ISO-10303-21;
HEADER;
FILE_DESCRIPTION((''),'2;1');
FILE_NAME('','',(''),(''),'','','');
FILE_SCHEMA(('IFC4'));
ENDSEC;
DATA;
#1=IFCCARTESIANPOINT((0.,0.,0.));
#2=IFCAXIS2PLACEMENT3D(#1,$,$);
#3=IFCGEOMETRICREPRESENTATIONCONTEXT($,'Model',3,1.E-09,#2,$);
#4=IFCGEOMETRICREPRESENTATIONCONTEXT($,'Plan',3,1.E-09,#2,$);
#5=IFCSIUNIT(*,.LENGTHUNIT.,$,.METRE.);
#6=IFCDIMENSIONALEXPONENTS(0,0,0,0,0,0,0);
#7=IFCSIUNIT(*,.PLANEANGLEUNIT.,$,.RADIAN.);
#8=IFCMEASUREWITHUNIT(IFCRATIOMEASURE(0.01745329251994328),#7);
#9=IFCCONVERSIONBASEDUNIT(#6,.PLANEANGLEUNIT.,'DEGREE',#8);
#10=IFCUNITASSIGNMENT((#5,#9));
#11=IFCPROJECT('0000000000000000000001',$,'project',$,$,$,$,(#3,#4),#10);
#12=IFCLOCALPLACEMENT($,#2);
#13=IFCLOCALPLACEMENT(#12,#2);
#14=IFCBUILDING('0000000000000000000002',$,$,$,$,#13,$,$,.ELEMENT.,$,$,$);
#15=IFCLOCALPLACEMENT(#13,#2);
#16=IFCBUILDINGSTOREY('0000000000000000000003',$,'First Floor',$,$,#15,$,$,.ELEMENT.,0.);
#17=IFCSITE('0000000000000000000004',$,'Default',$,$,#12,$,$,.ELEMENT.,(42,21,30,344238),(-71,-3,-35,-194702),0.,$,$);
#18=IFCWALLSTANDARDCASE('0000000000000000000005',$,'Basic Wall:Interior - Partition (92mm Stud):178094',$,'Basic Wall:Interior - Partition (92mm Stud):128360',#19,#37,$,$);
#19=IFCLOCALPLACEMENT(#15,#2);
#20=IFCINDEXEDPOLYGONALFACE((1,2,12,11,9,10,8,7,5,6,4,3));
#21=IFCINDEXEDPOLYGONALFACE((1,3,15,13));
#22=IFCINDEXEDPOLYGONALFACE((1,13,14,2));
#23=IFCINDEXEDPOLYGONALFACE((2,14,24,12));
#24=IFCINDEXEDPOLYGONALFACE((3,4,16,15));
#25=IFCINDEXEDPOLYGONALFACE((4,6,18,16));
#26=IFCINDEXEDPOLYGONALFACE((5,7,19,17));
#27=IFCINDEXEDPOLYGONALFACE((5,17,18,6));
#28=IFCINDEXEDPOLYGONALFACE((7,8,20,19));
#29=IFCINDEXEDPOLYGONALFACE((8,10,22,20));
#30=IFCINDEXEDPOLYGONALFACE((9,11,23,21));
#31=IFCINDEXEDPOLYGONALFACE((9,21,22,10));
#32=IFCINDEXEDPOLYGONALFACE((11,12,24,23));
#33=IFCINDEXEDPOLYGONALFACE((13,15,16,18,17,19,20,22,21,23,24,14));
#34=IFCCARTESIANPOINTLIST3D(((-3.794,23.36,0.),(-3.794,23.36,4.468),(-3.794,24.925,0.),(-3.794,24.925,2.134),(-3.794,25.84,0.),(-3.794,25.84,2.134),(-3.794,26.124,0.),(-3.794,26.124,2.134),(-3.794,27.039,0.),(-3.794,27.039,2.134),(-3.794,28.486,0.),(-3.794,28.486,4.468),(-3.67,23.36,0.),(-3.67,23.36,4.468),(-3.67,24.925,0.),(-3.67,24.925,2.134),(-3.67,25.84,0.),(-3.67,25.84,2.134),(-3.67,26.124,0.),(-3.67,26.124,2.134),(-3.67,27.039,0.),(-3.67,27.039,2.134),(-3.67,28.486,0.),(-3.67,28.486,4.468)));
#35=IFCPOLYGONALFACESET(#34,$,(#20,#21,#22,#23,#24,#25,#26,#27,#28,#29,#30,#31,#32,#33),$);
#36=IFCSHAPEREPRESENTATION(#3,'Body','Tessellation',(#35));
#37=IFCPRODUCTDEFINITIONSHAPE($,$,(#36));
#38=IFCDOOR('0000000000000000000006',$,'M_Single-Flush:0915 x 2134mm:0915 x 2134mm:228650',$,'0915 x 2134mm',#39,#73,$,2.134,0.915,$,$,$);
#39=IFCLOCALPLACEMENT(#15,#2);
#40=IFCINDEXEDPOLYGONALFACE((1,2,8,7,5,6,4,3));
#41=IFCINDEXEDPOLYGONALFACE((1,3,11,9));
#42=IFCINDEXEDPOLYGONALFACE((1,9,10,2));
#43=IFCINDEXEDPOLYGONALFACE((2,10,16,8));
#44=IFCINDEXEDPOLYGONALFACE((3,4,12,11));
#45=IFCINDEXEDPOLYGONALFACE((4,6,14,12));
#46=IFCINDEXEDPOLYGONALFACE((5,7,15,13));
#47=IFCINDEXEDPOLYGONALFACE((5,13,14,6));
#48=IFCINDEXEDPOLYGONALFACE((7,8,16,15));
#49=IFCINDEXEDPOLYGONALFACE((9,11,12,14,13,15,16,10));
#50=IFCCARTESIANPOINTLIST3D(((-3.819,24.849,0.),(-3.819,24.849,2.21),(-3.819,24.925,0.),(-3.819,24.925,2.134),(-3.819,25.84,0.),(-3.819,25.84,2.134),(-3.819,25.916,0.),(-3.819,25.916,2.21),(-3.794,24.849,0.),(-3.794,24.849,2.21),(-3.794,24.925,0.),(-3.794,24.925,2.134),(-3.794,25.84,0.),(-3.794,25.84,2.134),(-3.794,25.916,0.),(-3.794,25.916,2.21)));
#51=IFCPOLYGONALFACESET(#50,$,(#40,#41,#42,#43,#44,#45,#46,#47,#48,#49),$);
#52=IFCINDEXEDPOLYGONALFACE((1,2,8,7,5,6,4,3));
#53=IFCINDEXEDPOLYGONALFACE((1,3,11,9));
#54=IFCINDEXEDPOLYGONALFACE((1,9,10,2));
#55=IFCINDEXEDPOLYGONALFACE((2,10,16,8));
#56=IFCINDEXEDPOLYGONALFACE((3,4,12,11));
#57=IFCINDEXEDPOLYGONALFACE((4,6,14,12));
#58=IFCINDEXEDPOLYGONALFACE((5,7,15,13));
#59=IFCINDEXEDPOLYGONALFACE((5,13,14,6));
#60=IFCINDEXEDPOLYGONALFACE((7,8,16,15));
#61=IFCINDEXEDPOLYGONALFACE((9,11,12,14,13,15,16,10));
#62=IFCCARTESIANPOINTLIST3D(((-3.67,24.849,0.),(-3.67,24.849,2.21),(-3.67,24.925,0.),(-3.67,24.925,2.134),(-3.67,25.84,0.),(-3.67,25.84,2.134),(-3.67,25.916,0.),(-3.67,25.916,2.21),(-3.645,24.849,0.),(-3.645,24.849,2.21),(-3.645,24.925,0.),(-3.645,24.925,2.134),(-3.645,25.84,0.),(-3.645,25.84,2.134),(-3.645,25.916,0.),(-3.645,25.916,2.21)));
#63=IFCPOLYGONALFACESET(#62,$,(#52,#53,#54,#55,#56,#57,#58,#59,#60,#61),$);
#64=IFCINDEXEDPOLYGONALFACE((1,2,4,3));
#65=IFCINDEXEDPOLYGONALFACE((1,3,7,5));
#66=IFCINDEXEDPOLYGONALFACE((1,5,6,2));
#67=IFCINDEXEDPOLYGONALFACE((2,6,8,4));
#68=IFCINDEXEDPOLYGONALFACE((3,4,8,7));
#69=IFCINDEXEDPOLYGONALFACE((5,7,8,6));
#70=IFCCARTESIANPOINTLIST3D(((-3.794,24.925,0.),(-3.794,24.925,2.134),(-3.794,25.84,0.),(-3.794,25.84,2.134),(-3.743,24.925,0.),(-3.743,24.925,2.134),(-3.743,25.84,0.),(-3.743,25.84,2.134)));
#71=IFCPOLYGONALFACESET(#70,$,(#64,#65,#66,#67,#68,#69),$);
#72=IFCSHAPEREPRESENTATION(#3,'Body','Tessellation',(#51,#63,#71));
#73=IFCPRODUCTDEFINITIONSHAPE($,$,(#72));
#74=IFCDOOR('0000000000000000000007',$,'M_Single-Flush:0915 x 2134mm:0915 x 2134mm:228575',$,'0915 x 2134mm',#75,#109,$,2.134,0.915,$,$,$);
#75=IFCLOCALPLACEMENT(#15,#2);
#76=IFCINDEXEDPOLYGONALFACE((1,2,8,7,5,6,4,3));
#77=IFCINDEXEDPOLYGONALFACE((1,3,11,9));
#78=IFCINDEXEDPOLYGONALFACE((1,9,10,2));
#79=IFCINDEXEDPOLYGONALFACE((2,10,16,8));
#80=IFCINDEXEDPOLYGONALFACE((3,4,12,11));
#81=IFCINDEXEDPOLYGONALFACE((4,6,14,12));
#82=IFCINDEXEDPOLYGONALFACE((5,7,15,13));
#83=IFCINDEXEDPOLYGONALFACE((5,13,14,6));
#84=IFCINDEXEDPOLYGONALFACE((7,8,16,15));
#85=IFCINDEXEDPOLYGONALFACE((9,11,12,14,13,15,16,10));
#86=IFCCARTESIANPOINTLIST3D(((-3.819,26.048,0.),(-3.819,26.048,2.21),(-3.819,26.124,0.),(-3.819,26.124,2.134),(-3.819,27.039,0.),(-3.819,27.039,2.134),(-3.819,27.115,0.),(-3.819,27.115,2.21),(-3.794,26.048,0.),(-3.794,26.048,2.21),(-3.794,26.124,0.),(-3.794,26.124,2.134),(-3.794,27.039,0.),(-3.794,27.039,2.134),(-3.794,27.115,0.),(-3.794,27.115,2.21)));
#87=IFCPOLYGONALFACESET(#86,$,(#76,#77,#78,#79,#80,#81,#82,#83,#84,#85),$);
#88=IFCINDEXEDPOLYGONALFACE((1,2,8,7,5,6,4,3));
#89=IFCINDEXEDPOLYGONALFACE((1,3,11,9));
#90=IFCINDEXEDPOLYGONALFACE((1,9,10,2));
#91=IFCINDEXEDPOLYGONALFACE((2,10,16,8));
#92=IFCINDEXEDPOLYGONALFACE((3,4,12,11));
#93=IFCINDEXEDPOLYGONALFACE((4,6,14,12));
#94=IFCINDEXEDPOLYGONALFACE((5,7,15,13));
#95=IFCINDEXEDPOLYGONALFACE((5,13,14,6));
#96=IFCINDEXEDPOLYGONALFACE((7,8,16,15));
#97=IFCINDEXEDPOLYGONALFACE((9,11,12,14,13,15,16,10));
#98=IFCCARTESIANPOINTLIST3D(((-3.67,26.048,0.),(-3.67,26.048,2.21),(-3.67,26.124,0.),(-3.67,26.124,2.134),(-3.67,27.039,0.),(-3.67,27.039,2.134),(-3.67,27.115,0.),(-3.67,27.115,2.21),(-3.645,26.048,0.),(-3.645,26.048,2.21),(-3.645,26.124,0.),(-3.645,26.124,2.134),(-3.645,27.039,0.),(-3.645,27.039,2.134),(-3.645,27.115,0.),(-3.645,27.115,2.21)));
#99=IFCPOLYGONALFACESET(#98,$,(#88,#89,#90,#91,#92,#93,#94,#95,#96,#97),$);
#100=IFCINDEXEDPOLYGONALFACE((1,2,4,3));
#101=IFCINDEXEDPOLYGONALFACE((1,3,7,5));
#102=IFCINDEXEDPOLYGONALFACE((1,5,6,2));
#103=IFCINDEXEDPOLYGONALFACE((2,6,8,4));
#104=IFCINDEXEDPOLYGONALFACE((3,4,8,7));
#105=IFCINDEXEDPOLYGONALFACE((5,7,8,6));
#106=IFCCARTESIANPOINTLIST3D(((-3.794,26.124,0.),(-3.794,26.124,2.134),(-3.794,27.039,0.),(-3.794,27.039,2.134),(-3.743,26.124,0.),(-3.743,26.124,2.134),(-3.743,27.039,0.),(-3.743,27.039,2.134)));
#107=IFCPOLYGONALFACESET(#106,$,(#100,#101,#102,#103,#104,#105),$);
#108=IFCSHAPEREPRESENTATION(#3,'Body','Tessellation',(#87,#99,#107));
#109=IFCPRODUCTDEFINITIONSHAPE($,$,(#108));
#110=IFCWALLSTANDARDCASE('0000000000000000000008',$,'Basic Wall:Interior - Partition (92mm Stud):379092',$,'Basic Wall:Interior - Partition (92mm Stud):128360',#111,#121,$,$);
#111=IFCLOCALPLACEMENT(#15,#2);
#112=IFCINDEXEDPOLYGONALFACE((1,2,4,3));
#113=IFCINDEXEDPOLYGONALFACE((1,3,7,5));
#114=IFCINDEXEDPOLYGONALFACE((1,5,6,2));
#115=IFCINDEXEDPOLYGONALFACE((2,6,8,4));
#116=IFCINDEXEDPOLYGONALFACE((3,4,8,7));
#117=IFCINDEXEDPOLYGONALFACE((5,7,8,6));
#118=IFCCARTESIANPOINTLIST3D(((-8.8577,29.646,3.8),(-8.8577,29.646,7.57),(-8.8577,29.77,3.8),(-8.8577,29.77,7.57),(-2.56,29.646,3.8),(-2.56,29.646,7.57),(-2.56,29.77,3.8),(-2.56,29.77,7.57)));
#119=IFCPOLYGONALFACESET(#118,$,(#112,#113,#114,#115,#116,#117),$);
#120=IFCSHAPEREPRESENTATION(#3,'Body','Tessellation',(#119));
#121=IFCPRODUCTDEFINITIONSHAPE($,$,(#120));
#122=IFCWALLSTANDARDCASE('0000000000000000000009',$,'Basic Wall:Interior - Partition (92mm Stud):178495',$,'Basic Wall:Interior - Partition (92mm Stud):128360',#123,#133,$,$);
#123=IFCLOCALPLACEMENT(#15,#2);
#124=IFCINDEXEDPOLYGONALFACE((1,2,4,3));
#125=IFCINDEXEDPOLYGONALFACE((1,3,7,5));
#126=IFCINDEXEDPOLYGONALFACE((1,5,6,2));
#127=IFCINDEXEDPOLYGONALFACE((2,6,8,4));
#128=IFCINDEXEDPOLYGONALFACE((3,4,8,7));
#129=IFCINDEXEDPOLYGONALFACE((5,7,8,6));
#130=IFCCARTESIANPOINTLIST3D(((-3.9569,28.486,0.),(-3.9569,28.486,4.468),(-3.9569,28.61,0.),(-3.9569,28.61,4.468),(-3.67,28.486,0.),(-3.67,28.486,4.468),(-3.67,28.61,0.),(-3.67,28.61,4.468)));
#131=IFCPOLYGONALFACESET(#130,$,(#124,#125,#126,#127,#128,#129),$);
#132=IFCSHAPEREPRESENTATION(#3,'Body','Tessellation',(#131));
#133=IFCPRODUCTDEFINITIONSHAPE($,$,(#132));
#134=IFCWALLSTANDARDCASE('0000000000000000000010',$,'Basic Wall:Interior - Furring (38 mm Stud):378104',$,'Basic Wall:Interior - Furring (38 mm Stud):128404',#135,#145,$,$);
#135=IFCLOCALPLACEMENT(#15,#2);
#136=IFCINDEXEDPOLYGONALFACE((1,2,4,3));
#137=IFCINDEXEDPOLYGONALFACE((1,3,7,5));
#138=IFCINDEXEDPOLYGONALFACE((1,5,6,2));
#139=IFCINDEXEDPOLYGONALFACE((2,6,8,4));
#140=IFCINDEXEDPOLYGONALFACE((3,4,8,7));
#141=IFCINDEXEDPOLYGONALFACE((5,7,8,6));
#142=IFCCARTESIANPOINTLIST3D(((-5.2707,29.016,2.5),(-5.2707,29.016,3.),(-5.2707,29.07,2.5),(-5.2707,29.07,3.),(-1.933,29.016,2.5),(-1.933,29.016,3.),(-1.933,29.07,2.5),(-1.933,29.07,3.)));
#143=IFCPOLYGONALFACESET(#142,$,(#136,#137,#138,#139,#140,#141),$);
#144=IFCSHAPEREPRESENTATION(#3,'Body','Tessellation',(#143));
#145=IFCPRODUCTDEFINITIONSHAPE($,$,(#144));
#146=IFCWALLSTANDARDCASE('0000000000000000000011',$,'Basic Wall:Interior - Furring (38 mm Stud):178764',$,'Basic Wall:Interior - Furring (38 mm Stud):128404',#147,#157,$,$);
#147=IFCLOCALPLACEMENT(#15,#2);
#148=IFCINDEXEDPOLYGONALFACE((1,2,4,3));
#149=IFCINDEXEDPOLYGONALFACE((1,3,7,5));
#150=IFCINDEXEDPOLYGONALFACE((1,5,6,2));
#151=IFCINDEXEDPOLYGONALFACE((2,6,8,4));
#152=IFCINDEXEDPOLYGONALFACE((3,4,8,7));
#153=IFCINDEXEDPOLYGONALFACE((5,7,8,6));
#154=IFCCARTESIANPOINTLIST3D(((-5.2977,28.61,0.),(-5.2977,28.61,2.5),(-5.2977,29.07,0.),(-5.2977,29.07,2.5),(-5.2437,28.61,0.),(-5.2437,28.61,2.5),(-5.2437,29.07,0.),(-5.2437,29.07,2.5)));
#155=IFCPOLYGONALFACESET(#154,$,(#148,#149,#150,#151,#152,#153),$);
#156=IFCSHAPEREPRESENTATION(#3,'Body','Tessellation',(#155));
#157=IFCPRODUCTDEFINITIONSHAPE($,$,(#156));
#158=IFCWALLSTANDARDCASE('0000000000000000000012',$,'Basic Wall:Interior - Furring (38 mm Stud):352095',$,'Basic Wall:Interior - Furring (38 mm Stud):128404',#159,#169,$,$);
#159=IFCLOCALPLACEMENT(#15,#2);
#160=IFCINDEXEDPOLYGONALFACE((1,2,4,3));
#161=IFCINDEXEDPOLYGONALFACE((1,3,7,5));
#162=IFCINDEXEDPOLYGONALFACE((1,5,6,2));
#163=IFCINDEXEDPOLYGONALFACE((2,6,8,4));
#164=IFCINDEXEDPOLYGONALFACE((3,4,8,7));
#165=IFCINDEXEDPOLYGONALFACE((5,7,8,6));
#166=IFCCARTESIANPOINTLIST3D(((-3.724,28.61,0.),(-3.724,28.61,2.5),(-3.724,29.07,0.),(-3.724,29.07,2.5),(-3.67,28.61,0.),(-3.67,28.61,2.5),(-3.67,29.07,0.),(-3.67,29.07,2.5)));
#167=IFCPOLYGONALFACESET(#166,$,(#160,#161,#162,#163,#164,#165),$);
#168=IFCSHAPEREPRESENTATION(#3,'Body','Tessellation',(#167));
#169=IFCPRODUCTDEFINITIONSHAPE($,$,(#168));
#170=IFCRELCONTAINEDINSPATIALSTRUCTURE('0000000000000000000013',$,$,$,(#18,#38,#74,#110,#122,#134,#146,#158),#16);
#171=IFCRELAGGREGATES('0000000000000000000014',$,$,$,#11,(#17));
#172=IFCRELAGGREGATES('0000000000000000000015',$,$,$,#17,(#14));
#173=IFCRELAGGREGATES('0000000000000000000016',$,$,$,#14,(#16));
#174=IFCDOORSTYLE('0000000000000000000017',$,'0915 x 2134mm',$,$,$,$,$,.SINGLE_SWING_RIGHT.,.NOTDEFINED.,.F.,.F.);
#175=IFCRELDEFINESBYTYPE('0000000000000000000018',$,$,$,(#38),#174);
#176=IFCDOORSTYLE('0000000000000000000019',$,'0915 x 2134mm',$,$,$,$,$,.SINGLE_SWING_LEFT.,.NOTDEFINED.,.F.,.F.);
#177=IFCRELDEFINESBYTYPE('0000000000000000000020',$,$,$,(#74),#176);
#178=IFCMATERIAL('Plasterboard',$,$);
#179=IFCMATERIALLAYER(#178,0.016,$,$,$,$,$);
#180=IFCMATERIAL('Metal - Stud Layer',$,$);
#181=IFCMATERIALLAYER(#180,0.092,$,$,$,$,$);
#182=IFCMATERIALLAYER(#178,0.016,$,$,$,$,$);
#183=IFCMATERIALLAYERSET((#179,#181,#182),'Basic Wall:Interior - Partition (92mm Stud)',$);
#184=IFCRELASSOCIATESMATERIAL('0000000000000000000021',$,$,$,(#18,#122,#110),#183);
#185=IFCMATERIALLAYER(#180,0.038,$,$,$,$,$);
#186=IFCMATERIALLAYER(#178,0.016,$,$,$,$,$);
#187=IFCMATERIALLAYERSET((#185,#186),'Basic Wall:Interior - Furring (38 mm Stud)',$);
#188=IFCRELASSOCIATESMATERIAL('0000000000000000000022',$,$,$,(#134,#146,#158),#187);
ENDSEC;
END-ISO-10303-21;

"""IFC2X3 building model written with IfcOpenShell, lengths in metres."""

from ifc_helpers import new_model, entity, si_unit, converted_unit, frame, frame_2d, origin, origin_2d_with_axis, place, context, project, spatial, polyline, rectangle, outline, extrude, source, transform, mapped, material, layer, layer_set, layer_usage, type_object, type_shapes, element, fill, save


model = new_model("IFC2X3")

# Units and contexts
model_context = context("Model", 3, precision=1e-09, world=origin())
plan_context = context("Plan", 3, precision=1e-09, world=origin())
ifc_project = project(units=[si_unit("LENGTHUNIT", "METRE"), converted_unit("PLANEANGLEUNIT", "DEGREE", entity("IfcRatioMeasure", 0.01745329251994328), si_unit("PLANEANGLEUNIT", "RADIAN"), dimensions=[0, 0, 0, 0, 0, 0, 0])], contexts=[model_context, plan_context])

# Site, building, storey
site_placement = place(None, origin())
site = spatial("IfcSite", under=ifc_project, at=site_placement, Name="Default", CompositionType="ELEMENT", RefLatitude=(42, 21, 30, 344238), RefLongitude=(-71, -3, -35, -194702), RefElevation=0.0)
building_placement = place(site_placement, origin())
building = spatial("IfcBuilding", under=site, at=building_placement, CompositionType="ELEMENT")
storey_placement = place(building_placement, origin())
storey = spatial("IfcBuildingStorey", under=building, at=storey_placement, Name="First Floor", CompositionType="ELEMENT", Elevation=0.0)

# Wall, openings, doors
ifc_material_1 = material(Name="Plasterboard")
ifc_layer_1 = layer(ifc_material_1, 0.016)
ifc_material_2 = material(Name="Metal - Stud Layer")
ifc_layer_2 = layer(ifc_material_2, 0.092)
ifc_layer_3 = layer(ifc_material_1, 0.016)
ifc_layer_set_1 = layer_set([ifc_layer_1, ifc_layer_2, ifc_layer_3], Name="Basic Wall:Interior - Partition (92mm Stud)")
ifc_layer_usage_1 = layer_usage(ifc_layer_set_1, "AXIS2", "NEGATIVE", 0.062)
wall_1_placement = place(storey_placement, frame((-3.732, 28.486, 0.0), z_axis=(0.0, 0.0, 1.0), x_axis=(0.0, -1.0, 0.0)))
wall_1 = element("IfcWallStandardCase", 1, at=wall_1_placement, inside=storey, material=ifc_layer_usage_1, Name="Basic Wall:Interior - Partition (92mm Stud):178094", ObjectType="Basic Wall:Interior - Partition (92mm Stud):128360", context=model_context, shape_type="SweptSolid", body=[
    extrude(rectangle(XDim=5.126, YDim=0.124, at=frame_2d((2.563, 0.0), x_axis=(-1.0, 0.0))), origin(), (0.0, 0.0, 1.0), 4.468),
])
opening_1_placement = place(wall_1_placement, frame((2.362, 0.062, 0.0)))
opening_1 = element("IfcOpeningElement", 2, at=opening_1_placement, cuts=wall_1, ObjectType="Opening", context=model_context, shape_type="SweptSolid", body=[
    extrude(rectangle(XDim=0.915, YDim=2.134, at=frame_2d((1.067, 0.4575), x_axis=(0.0, -1.0))), frame((0.0, 0.0, 0.0), z_axis=(0.0, -1.0, 0.0), x_axis=(0.0, 0.0, 1.0)), (0.0, 0.0, 1.0), 0.124),
])
opening_2_placement = place(wall_1_placement, frame((3.561, 0.062, 0.0)))
opening_2 = element("IfcOpeningElement", 3, at=opening_2_placement, cuts=wall_1, ObjectType="Opening", context=model_context, shape_type="SweptSolid", body=[
    extrude(rectangle(XDim=0.915, YDim=2.134, at=frame_2d((1.067, 0.4575), x_axis=(0.0, 1.0))), frame((0.0, 0.0, 0.0), z_axis=(0.0, -1.0, 0.0), x_axis=(0.0, 0.0, 1.0)), (0.0, 0.0, 1.0), 0.124),
])
door_style_1 = type_object("IfcDoorStyle", Name="0915 x 2134mm", ConstructionType="NOTDEFINED", OperationType="SINGLE_SWING_RIGHT", ParameterTakesPrecedence=False, Sizeable=False)
shared_shape_1 = source(origin(), model_context, "Body", "SweptSolid", [
    extrude(outline(polyline([(-0.5335, -1.124), (0.5335, -1.124), (0.5335, 1.086), (0.4575, 1.086), (0.4575, -1.048), (-0.4575, -1.048), (-0.4575, 1.086), (-0.5335, 1.086), (-0.5335, -1.124)])), frame((0.4575, 0.124, 1.086), z_axis=(0.0, 1.0, 0.0), x_axis=(1.0, 0.0, 0.0)), (0.0, 0.0, 1.0), 0.025),
    extrude(outline(polyline([(-1.124, -0.5335), (1.086, -0.5335), (1.086, -0.4575), (-1.048, -0.4575), (-1.048, 0.4575), (1.086, 0.4575), (1.086, 0.5335), (-1.124, 0.5335), (-1.124, -0.5335)])), frame((0.4575, -0.025, 1.086), z_axis=(0.0, 1.0, 0.0), x_axis=(0.0, 0.0, -1.0)), (0.0, 0.0, 1.0), 0.025),
    extrude(rectangle(XDim=0.051, YDim=0.915, at=origin_2d_with_axis()), frame((0.4575, 0.0985, 0.0), z_axis=(0.0, 0.0, 1.0), x_axis=(0.0, 1.0, 0.0)), (0.0, 0.0, 1.0), 2.134),
])
type_shapes(door_style_1, [shared_shape_1])
door_1_placement = place(opening_2_placement, frame((0.0, 0.0, 0.0), z_axis=(0.0, 0.0, 1.0), x_axis=(-1.0, 0.0, 0.0)))
door_1 = element("IfcDoor", 4, at=door_1_placement, inside=storey, type_object=door_style_1, Name="M_Single-Flush:0915 x 2134mm:0915 x 2134mm:228650", ObjectType="0915 x 2134mm", OverallHeight=2.134, OverallWidth=0.915, context=model_context, shape_type="MappedRepresentation", body=[
    mapped(shared_shape_1, transform((0.0, 0.0, 0.0), scale=1.0)),
])
fill(opening_2, door_1)
door_style_2 = type_object("IfcDoorStyle", Name="0915 x 2134mm", ConstructionType="NOTDEFINED", OperationType="SINGLE_SWING_LEFT", ParameterTakesPrecedence=False, Sizeable=False)
shared_shape_2 = source(origin(), model_context, "Body", "SweptSolid", [
    extrude(outline(polyline([(-0.5335, -1.124), (0.5335, -1.124), (0.5335, 1.086), (0.4575, 1.086), (0.4575, -1.048), (-0.4575, -1.048), (-0.4575, 1.086), (-0.5335, 1.086), (-0.5335, -1.124)])), frame((0.4575, 0.149, 1.086), z_axis=(0.0, -1.0, 0.0), x_axis=(-1.0, 0.0, 0.0)), (0.0, 0.0, 1.0), 0.025),
    extrude(outline(polyline([(-1.124, -0.5335), (1.086, -0.5335), (1.086, -0.4575), (-1.048, -0.4575), (-1.048, 0.4575), (1.086, 0.4575), (1.086, 0.5335), (-1.124, 0.5335), (-1.124, -0.5335)])), frame((0.4575, 0.0, 1.086), z_axis=(0.0, -1.0, 0.0), x_axis=(0.0, 0.0, -1.0)), (0.0, 0.0, 1.0), 0.025),
    extrude(rectangle(XDim=0.915, YDim=0.051, at=origin_2d_with_axis()), frame((0.4575, 0.0985, 0.0)), (0.0, 0.0, 1.0), 2.134),
])
type_shapes(door_style_2, [shared_shape_2])
door_2_placement = place(opening_1_placement, frame((0.0, 0.0, 0.0), z_axis=(0.0, 0.0, 1.0), x_axis=(-1.0, 0.0, 0.0)))
door_2 = element("IfcDoor", 5, at=door_2_placement, inside=storey, type_object=door_style_2, Name="M_Single-Flush:0915 x 2134mm:0915 x 2134mm:228575", ObjectType="0915 x 2134mm", OverallHeight=2.134, OverallWidth=0.915, context=model_context, shape_type="MappedRepresentation", body=[
    mapped(shared_shape_2, transform((0.0, 0.0, 0.0), scale=1.0)),
])
fill(opening_1, door_2)

# Walls
ifc_layer_usage_2 = layer_usage(ifc_layer_set_1, "AXIS2", "POSITIVE", -0.062)
wall_2_placement = place(storey_placement, frame((-2.498, 29.708, 3.8), z_axis=(0.0, 0.0, 1.0), x_axis=(-1.0, 0.0, 0.0)))
element("IfcWallStandardCase", 6, at=wall_2_placement, inside=storey, material=ifc_layer_usage_2, Name="Basic Wall:Interior - Partition (92mm Stud):379092", ObjectType="Basic Wall:Interior - Partition (92mm Stud):128360", context=model_context, shape_type="SweptSolid", body=[
    extrude(rectangle(XDim=6.2977, YDim=0.124, at=frame_2d((3.2109, 0.0), x_axis=(-1.0, 0.0))), origin(), (0.0, 0.0, 1.0), 3.77),
])
wall_3_placement = place(storey_placement, frame((-3.9569, 28.548, 0.0)))
element("IfcWallStandardCase", 7, at=wall_3_placement, inside=storey, material=ifc_layer_usage_1, Name="Basic Wall:Interior - Partition (92mm Stud):178495", ObjectType="Basic Wall:Interior - Partition (92mm Stud):128360", context=model_context, shape_type="SweptSolid", body=[
    extrude(rectangle(XDim=0.2869, YDim=0.124, at=frame_2d((0.1434, 0.0), x_axis=(-1.0, 0.0))), origin(), (0.0, 0.0, 1.0), 4.468),
])
ifc_layer_4 = layer(ifc_material_2, 0.038)
ifc_layer_5 = layer(ifc_material_1, 0.016)
ifc_layer_set_2 = layer_set([ifc_layer_4, ifc_layer_5], Name="Basic Wall:Interior - Furring (38 mm Stud)")
ifc_layer_usage_3 = layer_usage(ifc_layer_set_2, "AXIS2", "POSITIVE", -0.027)
wall_4_placement = place(storey_placement, frame((-5.2707, 29.043, 2.5)))
element("IfcWallStandardCase", 8, at=wall_4_placement, inside=storey, material=ifc_layer_usage_3, Name="Basic Wall:Interior - Furring (38 mm Stud):378104", ObjectType="Basic Wall:Interior - Furring (38 mm Stud):128404", context=model_context, shape_type="SweptSolid", body=[
    extrude(rectangle(XDim=3.3377, YDim=0.054, at=frame_2d((1.6689, 0.0), x_axis=(-1.0, 0.0))), origin(), (0.0, 0.0, 1.0), 0.5),
])
wall_5_placement = place(storey_placement, frame((-5.2707, 29.07, 0.0), z_axis=(0.0, 0.0, 1.0), x_axis=(0.0, -1.0, 0.0)))
element("IfcWallStandardCase", 9, at=wall_5_placement, inside=storey, material=ifc_layer_usage_3, Name="Basic Wall:Interior - Furring (38 mm Stud):178764", ObjectType="Basic Wall:Interior - Furring (38 mm Stud):128404", context=model_context, shape_type="SweptSolid", body=[
    extrude(rectangle(XDim=0.46, YDim=0.054, at=frame_2d((0.23, 0.0), x_axis=(-1.0, 0.0))), origin(), (0.0, 0.0, 1.0), 2.5),
])
wall_6_placement = place(storey_placement, frame((-3.697, 29.07, 0.0), z_axis=(0.0, 0.0, 1.0), x_axis=(0.0, -1.0, 0.0)))
element("IfcWallStandardCase", 10, at=wall_6_placement, inside=storey, material=ifc_layer_usage_3, Name="Basic Wall:Interior - Furring (38 mm Stud):352095", ObjectType="Basic Wall:Interior - Furring (38 mm Stud):128404", context=model_context, shape_type="SweptSolid", body=[
    extrude(rectangle(XDim=0.46, YDim=0.054, at=frame_2d((0.23, 0.0), x_axis=(-1.0, 0.0))), origin(), (0.0, 0.0, 1.0), 2.5),
])

save(model, "model.ifc")
